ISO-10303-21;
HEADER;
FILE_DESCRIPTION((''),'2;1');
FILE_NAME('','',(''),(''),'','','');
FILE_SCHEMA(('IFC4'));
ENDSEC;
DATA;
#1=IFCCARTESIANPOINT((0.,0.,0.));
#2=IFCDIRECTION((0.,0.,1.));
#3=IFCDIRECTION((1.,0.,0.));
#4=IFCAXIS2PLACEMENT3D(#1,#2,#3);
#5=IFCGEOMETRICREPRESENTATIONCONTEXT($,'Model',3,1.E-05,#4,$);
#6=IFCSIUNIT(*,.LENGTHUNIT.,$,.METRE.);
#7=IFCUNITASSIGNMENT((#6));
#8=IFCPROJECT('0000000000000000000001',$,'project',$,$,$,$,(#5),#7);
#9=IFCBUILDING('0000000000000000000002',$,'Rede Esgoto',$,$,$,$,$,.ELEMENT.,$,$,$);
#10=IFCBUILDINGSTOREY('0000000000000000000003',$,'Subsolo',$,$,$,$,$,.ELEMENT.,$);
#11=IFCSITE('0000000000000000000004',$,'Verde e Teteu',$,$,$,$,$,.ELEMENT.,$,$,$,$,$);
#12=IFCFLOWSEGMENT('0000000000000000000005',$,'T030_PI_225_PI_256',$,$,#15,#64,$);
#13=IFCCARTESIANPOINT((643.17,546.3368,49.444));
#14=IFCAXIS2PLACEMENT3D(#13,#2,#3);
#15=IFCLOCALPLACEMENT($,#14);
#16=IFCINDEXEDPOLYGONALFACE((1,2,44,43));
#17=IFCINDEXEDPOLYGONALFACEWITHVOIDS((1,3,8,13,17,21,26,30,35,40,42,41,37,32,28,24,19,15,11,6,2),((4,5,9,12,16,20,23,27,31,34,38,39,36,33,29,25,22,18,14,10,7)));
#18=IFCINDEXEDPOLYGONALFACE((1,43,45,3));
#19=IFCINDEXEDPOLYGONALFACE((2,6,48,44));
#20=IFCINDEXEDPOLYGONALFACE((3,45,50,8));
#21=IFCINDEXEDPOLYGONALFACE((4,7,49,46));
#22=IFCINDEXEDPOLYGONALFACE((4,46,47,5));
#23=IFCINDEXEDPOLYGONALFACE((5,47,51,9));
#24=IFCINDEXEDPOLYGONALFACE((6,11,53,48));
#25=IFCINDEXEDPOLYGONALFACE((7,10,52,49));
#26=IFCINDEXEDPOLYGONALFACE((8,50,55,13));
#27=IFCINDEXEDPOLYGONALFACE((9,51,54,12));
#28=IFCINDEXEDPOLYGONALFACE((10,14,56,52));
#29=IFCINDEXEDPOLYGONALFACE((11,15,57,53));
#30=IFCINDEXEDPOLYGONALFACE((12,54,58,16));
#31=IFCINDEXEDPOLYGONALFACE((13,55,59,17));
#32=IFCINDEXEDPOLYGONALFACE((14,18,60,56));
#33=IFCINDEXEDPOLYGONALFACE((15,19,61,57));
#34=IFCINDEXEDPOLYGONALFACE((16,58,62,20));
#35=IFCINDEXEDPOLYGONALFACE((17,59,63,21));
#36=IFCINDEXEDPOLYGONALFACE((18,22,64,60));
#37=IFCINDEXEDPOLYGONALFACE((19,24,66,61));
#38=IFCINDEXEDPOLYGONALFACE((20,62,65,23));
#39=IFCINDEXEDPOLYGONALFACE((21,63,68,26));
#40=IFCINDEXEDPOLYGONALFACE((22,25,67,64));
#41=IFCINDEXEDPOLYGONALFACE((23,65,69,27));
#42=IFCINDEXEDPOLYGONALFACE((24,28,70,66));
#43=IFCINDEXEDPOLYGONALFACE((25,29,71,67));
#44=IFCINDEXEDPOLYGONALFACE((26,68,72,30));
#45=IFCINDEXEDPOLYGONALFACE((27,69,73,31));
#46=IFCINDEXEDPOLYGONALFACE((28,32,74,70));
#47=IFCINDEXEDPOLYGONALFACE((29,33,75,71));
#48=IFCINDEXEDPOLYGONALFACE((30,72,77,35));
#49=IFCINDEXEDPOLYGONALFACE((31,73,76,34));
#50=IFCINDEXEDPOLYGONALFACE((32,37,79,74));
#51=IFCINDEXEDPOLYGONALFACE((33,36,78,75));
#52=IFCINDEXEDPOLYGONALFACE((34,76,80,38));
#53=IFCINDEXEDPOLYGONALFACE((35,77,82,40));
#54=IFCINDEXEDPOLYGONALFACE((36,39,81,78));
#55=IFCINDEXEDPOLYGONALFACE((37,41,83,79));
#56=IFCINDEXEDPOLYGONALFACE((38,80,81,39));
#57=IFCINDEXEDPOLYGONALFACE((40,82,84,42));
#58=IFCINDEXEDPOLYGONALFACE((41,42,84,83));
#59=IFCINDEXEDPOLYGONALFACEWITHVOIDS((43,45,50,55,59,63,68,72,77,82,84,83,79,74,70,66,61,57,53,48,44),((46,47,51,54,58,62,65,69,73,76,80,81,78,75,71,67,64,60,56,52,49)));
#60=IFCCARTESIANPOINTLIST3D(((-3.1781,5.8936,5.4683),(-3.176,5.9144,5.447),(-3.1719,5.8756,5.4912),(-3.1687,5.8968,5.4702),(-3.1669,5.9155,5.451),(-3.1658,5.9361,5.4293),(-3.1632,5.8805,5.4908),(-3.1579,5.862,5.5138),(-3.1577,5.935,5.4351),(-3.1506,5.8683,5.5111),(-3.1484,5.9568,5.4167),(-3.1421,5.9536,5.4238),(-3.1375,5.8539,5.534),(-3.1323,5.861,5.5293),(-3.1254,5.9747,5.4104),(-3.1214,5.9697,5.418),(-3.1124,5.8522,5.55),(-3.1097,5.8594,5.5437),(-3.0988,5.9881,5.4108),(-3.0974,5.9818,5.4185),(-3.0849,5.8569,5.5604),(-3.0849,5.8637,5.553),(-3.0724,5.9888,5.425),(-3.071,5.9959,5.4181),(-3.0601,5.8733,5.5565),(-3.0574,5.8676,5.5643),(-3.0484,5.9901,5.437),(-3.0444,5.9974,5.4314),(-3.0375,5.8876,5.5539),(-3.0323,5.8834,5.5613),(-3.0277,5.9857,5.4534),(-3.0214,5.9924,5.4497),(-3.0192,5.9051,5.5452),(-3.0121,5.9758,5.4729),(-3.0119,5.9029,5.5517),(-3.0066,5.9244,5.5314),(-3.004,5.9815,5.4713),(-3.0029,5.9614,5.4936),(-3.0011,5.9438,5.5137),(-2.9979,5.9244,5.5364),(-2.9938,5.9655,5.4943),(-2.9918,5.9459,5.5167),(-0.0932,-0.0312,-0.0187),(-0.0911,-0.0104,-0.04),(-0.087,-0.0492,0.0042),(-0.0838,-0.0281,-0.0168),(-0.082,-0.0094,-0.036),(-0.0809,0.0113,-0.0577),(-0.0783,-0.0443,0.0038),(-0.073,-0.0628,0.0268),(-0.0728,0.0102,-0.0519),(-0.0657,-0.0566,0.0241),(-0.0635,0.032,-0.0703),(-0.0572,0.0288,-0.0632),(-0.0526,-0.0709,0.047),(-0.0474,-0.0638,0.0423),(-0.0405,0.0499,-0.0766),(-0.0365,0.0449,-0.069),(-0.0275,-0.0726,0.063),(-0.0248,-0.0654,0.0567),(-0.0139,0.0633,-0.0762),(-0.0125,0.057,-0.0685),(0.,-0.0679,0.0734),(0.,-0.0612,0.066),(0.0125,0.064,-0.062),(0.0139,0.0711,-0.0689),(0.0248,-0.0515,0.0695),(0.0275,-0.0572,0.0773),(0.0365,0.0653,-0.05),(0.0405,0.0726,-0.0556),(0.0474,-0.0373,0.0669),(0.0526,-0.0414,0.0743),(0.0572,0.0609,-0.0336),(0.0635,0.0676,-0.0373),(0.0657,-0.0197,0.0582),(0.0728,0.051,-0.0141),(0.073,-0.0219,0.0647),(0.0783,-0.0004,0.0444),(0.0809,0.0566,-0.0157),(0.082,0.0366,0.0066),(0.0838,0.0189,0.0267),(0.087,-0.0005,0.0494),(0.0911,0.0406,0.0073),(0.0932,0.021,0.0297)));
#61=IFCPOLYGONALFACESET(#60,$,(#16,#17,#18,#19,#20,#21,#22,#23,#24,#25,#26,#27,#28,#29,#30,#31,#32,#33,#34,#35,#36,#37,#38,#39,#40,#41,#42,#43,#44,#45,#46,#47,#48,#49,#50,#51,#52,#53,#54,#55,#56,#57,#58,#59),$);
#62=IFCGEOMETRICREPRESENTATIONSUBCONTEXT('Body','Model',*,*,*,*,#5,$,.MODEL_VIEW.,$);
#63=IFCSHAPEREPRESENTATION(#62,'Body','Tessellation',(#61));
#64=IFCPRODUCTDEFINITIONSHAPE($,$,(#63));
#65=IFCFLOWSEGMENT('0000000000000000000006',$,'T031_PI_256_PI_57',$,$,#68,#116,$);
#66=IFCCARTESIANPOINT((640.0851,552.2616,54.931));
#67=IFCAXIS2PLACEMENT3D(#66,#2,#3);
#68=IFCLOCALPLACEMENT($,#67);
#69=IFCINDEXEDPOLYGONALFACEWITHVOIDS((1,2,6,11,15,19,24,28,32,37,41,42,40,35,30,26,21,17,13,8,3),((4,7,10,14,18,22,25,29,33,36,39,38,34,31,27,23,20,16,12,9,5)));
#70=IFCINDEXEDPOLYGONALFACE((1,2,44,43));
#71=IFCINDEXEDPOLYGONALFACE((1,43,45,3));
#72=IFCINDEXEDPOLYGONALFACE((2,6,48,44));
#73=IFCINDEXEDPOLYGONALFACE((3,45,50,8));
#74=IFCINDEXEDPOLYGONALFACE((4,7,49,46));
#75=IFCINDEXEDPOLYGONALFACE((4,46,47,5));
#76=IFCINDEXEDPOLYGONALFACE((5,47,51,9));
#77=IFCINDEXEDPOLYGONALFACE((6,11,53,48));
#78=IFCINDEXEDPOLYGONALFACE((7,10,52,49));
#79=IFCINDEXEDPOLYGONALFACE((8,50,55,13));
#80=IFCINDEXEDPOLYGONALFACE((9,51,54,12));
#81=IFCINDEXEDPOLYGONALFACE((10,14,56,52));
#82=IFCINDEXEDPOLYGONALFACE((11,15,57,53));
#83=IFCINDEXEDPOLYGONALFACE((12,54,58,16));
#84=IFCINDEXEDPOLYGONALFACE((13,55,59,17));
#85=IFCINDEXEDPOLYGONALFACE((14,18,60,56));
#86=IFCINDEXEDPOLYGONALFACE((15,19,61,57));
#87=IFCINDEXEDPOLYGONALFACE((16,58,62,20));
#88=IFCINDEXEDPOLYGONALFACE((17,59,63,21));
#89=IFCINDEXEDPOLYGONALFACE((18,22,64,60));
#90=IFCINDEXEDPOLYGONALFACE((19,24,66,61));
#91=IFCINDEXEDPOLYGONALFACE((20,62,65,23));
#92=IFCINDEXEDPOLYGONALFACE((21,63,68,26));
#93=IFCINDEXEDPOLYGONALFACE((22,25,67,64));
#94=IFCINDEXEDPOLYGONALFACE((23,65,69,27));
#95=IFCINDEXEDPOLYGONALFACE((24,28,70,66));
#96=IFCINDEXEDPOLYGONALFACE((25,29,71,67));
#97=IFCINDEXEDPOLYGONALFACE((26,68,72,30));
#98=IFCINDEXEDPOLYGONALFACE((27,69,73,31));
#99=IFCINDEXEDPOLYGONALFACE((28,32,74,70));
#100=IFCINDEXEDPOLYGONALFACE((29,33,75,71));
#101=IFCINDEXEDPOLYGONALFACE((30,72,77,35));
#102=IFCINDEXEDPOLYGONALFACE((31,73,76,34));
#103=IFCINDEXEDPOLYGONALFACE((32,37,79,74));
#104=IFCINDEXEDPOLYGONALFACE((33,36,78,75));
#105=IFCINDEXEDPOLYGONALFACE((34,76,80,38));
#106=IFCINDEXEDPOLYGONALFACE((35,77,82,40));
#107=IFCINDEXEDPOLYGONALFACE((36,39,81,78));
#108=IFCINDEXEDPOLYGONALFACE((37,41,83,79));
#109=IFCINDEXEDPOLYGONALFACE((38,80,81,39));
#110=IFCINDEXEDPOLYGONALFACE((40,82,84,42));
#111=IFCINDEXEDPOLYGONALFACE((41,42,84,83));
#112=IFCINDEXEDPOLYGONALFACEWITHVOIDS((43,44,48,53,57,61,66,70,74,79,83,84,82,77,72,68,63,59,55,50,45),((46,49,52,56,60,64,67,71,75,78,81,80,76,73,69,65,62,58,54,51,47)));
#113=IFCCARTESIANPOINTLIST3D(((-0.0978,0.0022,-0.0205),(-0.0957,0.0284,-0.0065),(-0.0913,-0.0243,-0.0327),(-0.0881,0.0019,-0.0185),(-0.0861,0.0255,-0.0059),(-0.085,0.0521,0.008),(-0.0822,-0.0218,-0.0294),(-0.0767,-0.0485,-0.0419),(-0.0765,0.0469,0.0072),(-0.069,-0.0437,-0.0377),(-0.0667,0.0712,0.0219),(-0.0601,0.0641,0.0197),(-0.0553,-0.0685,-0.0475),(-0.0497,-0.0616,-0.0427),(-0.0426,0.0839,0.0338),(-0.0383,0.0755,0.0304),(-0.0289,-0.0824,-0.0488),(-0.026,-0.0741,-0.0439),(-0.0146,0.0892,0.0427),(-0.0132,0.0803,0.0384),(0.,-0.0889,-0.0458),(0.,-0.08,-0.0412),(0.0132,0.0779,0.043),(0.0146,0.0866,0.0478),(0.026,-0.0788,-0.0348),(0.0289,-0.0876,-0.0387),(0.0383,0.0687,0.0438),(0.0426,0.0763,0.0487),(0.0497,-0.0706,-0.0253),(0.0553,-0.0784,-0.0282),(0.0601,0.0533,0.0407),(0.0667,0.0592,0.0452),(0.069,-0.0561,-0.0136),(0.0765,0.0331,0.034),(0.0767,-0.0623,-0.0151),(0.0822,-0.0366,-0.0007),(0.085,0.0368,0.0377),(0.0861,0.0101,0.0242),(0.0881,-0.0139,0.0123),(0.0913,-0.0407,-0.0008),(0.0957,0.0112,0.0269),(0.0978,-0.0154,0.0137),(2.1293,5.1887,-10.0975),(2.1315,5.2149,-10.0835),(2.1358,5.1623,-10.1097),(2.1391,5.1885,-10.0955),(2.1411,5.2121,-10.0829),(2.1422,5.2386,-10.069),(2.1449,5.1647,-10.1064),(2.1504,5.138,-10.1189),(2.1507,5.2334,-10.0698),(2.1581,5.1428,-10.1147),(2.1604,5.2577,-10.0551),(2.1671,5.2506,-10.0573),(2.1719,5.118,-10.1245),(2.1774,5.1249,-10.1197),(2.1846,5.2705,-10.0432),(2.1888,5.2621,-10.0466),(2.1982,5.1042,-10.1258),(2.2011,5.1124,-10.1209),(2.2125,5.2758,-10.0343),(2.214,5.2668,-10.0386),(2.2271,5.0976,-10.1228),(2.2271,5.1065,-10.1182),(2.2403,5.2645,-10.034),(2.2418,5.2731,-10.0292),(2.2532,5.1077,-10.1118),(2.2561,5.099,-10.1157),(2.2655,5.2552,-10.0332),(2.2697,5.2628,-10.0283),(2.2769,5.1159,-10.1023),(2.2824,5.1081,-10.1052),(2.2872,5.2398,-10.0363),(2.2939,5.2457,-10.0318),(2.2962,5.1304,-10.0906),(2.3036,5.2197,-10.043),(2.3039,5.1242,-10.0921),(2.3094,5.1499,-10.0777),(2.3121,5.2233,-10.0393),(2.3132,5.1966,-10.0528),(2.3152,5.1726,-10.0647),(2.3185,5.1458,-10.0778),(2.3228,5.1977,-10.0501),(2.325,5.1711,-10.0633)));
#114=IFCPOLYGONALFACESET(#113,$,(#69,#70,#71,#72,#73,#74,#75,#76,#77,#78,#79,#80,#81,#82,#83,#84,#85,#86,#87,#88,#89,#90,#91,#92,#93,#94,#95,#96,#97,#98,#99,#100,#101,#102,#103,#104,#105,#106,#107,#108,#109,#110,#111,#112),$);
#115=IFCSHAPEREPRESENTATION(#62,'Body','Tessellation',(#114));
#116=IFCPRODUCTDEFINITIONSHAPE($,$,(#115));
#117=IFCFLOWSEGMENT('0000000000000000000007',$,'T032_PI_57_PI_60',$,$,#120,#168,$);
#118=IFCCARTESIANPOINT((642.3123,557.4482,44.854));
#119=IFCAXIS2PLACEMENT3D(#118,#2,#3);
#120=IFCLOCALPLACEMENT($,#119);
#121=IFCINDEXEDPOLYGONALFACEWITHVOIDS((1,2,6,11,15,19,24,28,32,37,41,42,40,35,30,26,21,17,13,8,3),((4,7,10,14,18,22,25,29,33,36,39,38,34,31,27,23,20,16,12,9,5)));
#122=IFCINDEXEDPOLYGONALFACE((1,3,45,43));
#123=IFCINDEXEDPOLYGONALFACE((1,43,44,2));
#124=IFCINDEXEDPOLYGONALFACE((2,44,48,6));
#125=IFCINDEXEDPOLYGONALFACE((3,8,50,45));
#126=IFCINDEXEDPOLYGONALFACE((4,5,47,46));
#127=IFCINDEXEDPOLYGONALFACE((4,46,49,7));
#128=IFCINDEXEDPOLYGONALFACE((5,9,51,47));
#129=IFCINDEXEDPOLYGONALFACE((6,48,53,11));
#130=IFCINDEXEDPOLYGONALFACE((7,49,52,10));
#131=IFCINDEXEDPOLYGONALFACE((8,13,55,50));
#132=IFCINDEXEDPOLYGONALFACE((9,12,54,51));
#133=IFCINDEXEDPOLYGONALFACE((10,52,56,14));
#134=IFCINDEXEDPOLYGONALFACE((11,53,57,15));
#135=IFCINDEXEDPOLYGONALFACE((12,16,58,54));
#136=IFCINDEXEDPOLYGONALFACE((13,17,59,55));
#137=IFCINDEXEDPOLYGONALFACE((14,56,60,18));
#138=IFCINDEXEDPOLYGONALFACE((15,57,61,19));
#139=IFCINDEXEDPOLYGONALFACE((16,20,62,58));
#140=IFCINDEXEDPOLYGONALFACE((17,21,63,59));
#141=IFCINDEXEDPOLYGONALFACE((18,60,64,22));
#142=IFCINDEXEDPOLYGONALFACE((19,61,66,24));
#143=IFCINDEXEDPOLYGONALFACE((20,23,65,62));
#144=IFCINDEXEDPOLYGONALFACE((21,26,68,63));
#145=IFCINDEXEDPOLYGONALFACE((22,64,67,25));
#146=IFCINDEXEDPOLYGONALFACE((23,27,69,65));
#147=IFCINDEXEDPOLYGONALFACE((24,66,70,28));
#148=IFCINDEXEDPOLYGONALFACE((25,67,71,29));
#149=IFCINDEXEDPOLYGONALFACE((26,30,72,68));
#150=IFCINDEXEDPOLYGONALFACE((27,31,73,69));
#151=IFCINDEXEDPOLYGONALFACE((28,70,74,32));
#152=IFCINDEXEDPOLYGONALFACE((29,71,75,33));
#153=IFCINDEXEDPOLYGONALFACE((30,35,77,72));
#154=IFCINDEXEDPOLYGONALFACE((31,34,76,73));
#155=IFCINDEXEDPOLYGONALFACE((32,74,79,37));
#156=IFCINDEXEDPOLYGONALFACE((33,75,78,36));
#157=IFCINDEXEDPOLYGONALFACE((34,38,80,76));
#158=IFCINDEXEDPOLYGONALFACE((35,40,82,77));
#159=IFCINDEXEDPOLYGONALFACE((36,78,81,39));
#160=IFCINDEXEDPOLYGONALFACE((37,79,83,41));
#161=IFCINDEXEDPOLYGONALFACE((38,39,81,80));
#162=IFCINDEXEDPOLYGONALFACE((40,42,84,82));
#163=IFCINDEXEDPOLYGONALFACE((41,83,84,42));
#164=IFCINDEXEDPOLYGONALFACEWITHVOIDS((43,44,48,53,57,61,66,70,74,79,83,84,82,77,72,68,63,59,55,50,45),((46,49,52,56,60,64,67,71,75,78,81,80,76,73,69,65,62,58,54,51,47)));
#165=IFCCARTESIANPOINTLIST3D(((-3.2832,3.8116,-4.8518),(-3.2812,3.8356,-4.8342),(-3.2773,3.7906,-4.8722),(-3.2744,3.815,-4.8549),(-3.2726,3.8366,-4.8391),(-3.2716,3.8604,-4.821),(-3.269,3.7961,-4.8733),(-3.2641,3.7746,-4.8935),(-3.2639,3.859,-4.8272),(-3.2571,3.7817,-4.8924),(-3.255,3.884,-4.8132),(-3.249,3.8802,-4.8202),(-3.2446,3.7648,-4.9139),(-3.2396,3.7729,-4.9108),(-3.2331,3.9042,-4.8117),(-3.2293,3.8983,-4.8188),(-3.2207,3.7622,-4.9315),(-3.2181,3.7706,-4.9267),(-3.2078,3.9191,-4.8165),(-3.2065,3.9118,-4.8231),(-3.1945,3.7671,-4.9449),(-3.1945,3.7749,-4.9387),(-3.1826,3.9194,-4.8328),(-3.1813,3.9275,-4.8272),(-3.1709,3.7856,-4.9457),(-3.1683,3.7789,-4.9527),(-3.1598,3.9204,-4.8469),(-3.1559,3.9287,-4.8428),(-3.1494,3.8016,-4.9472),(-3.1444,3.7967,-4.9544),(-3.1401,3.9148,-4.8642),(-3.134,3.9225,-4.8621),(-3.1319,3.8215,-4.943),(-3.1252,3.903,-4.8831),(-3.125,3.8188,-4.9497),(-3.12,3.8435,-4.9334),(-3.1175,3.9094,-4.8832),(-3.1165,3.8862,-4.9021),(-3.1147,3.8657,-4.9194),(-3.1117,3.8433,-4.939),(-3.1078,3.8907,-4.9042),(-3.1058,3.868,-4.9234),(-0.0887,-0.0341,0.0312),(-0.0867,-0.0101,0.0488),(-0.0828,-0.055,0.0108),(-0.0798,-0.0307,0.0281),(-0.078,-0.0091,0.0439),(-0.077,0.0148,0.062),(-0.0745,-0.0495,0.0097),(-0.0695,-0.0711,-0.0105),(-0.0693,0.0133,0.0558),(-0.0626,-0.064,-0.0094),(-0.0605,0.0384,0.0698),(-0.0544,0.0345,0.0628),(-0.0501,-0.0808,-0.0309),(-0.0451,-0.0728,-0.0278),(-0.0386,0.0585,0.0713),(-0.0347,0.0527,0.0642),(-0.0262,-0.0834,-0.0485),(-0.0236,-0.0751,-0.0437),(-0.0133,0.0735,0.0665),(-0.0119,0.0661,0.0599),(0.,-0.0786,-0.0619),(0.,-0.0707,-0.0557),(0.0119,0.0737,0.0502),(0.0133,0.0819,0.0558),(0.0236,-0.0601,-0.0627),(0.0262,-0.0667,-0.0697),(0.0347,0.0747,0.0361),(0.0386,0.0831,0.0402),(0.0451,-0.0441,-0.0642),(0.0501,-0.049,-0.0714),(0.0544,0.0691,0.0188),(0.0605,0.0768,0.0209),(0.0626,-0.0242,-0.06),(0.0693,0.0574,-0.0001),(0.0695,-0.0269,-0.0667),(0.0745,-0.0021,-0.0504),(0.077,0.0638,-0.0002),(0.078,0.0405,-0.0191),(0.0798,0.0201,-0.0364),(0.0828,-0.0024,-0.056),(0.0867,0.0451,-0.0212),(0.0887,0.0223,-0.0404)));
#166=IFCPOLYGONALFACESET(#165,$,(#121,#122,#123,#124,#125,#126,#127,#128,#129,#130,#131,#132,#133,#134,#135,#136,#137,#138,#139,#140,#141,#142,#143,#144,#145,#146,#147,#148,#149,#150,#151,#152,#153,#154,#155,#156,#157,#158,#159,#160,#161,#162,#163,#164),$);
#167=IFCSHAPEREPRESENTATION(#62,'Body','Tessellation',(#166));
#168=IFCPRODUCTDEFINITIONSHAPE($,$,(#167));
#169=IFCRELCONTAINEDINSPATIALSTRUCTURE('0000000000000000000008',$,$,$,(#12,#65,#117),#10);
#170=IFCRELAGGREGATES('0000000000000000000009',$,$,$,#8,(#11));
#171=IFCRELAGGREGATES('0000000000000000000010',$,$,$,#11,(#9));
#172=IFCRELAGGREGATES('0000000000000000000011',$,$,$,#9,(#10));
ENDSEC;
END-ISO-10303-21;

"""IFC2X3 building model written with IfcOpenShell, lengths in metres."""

from ifc_helpers import new_model, entity, si_unit, frame, origin_with_axes, place, context, subcontext, project, spatial, element, save


model = new_model("IFC2X3")

# Units and contexts
model_context = context("Model", 3, precision=1e-05, world=origin_with_axes())
body_context = subcontext(model_context, "Body", "Model", "MODEL_VIEW")
ifc_project = project(units=[si_unit("LENGTHUNIT", "METRE")], contexts=[model_context])

# Site, building, storey
site = spatial("IfcSite", under=ifc_project, Name="Verde e Teteu", CompositionType="ELEMENT")
building = spatial("IfcBuilding", under=site, Name="Rede Esgoto", CompositionType="ELEMENT")
storey = spatial("IfcBuildingStorey", under=building, Name="Subsolo", CompositionType="ELEMENT")

# Flow segments
flow_segment_1_placement = place(None, frame((643.17, 546.3368, 49.444), z_axis=(0.0, 0.0, 1.0), x_axis=(1.0, 0.0, 0.0)))
element("IfcFlowSegment", 1, at=flow_segment_1_placement, inside=storey, Name="T030_PI_225_PI_256", context=body_context, shape_type="SweptSolid", body=[
    entity("IfcSweptDiskSolid", entity("IfcPolyline", [entity("IfcCartesianPoint", [0.0, 0.0, 0.0]), entity("IfcCartesianPoint", [-3.0849, 5.9248, 5.487])]), 0.1, 0.09),
])
flow_segment_2_placement = place(None, frame((640.0851, 552.2616, 54.931), z_axis=(0.0, 0.0, 1.0), x_axis=(1.0, 0.0, 0.0)))
element("IfcFlowSegment", 2, at=flow_segment_2_placement, inside=storey, Name="T031_PI_256_PI_57", context=body_context, shape_type="SweptSolid", body=[
    entity("IfcSweptDiskSolid", entity("IfcPolyline", [entity("IfcCartesianPoint", [0.0, 0.0, 0.0]), entity("IfcCartesianPoint", [2.2271, 5.1865, -10.077])]), 0.1, 0.09),
])
flow_segment_3_placement = place(None, frame((642.3123, 557.4482, 44.854), z_axis=(0.0, 0.0, 1.0), x_axis=(1.0, 0.0, 0.0)))
element("IfcFlowSegment", 3, at=flow_segment_3_placement, inside=storey, Name="T032_PI_57_PI_60", context=body_context, shape_type="SweptSolid", body=[
    entity("IfcSweptDiskSolid", entity("IfcPolyline", [entity("IfcCartesianPoint", [0.0, 0.0, 0.0]), entity("IfcCartesianPoint", [-3.1945, 3.8456, -4.883])]), 0.1, 0.09),
])

save(model, "model.ifc")
